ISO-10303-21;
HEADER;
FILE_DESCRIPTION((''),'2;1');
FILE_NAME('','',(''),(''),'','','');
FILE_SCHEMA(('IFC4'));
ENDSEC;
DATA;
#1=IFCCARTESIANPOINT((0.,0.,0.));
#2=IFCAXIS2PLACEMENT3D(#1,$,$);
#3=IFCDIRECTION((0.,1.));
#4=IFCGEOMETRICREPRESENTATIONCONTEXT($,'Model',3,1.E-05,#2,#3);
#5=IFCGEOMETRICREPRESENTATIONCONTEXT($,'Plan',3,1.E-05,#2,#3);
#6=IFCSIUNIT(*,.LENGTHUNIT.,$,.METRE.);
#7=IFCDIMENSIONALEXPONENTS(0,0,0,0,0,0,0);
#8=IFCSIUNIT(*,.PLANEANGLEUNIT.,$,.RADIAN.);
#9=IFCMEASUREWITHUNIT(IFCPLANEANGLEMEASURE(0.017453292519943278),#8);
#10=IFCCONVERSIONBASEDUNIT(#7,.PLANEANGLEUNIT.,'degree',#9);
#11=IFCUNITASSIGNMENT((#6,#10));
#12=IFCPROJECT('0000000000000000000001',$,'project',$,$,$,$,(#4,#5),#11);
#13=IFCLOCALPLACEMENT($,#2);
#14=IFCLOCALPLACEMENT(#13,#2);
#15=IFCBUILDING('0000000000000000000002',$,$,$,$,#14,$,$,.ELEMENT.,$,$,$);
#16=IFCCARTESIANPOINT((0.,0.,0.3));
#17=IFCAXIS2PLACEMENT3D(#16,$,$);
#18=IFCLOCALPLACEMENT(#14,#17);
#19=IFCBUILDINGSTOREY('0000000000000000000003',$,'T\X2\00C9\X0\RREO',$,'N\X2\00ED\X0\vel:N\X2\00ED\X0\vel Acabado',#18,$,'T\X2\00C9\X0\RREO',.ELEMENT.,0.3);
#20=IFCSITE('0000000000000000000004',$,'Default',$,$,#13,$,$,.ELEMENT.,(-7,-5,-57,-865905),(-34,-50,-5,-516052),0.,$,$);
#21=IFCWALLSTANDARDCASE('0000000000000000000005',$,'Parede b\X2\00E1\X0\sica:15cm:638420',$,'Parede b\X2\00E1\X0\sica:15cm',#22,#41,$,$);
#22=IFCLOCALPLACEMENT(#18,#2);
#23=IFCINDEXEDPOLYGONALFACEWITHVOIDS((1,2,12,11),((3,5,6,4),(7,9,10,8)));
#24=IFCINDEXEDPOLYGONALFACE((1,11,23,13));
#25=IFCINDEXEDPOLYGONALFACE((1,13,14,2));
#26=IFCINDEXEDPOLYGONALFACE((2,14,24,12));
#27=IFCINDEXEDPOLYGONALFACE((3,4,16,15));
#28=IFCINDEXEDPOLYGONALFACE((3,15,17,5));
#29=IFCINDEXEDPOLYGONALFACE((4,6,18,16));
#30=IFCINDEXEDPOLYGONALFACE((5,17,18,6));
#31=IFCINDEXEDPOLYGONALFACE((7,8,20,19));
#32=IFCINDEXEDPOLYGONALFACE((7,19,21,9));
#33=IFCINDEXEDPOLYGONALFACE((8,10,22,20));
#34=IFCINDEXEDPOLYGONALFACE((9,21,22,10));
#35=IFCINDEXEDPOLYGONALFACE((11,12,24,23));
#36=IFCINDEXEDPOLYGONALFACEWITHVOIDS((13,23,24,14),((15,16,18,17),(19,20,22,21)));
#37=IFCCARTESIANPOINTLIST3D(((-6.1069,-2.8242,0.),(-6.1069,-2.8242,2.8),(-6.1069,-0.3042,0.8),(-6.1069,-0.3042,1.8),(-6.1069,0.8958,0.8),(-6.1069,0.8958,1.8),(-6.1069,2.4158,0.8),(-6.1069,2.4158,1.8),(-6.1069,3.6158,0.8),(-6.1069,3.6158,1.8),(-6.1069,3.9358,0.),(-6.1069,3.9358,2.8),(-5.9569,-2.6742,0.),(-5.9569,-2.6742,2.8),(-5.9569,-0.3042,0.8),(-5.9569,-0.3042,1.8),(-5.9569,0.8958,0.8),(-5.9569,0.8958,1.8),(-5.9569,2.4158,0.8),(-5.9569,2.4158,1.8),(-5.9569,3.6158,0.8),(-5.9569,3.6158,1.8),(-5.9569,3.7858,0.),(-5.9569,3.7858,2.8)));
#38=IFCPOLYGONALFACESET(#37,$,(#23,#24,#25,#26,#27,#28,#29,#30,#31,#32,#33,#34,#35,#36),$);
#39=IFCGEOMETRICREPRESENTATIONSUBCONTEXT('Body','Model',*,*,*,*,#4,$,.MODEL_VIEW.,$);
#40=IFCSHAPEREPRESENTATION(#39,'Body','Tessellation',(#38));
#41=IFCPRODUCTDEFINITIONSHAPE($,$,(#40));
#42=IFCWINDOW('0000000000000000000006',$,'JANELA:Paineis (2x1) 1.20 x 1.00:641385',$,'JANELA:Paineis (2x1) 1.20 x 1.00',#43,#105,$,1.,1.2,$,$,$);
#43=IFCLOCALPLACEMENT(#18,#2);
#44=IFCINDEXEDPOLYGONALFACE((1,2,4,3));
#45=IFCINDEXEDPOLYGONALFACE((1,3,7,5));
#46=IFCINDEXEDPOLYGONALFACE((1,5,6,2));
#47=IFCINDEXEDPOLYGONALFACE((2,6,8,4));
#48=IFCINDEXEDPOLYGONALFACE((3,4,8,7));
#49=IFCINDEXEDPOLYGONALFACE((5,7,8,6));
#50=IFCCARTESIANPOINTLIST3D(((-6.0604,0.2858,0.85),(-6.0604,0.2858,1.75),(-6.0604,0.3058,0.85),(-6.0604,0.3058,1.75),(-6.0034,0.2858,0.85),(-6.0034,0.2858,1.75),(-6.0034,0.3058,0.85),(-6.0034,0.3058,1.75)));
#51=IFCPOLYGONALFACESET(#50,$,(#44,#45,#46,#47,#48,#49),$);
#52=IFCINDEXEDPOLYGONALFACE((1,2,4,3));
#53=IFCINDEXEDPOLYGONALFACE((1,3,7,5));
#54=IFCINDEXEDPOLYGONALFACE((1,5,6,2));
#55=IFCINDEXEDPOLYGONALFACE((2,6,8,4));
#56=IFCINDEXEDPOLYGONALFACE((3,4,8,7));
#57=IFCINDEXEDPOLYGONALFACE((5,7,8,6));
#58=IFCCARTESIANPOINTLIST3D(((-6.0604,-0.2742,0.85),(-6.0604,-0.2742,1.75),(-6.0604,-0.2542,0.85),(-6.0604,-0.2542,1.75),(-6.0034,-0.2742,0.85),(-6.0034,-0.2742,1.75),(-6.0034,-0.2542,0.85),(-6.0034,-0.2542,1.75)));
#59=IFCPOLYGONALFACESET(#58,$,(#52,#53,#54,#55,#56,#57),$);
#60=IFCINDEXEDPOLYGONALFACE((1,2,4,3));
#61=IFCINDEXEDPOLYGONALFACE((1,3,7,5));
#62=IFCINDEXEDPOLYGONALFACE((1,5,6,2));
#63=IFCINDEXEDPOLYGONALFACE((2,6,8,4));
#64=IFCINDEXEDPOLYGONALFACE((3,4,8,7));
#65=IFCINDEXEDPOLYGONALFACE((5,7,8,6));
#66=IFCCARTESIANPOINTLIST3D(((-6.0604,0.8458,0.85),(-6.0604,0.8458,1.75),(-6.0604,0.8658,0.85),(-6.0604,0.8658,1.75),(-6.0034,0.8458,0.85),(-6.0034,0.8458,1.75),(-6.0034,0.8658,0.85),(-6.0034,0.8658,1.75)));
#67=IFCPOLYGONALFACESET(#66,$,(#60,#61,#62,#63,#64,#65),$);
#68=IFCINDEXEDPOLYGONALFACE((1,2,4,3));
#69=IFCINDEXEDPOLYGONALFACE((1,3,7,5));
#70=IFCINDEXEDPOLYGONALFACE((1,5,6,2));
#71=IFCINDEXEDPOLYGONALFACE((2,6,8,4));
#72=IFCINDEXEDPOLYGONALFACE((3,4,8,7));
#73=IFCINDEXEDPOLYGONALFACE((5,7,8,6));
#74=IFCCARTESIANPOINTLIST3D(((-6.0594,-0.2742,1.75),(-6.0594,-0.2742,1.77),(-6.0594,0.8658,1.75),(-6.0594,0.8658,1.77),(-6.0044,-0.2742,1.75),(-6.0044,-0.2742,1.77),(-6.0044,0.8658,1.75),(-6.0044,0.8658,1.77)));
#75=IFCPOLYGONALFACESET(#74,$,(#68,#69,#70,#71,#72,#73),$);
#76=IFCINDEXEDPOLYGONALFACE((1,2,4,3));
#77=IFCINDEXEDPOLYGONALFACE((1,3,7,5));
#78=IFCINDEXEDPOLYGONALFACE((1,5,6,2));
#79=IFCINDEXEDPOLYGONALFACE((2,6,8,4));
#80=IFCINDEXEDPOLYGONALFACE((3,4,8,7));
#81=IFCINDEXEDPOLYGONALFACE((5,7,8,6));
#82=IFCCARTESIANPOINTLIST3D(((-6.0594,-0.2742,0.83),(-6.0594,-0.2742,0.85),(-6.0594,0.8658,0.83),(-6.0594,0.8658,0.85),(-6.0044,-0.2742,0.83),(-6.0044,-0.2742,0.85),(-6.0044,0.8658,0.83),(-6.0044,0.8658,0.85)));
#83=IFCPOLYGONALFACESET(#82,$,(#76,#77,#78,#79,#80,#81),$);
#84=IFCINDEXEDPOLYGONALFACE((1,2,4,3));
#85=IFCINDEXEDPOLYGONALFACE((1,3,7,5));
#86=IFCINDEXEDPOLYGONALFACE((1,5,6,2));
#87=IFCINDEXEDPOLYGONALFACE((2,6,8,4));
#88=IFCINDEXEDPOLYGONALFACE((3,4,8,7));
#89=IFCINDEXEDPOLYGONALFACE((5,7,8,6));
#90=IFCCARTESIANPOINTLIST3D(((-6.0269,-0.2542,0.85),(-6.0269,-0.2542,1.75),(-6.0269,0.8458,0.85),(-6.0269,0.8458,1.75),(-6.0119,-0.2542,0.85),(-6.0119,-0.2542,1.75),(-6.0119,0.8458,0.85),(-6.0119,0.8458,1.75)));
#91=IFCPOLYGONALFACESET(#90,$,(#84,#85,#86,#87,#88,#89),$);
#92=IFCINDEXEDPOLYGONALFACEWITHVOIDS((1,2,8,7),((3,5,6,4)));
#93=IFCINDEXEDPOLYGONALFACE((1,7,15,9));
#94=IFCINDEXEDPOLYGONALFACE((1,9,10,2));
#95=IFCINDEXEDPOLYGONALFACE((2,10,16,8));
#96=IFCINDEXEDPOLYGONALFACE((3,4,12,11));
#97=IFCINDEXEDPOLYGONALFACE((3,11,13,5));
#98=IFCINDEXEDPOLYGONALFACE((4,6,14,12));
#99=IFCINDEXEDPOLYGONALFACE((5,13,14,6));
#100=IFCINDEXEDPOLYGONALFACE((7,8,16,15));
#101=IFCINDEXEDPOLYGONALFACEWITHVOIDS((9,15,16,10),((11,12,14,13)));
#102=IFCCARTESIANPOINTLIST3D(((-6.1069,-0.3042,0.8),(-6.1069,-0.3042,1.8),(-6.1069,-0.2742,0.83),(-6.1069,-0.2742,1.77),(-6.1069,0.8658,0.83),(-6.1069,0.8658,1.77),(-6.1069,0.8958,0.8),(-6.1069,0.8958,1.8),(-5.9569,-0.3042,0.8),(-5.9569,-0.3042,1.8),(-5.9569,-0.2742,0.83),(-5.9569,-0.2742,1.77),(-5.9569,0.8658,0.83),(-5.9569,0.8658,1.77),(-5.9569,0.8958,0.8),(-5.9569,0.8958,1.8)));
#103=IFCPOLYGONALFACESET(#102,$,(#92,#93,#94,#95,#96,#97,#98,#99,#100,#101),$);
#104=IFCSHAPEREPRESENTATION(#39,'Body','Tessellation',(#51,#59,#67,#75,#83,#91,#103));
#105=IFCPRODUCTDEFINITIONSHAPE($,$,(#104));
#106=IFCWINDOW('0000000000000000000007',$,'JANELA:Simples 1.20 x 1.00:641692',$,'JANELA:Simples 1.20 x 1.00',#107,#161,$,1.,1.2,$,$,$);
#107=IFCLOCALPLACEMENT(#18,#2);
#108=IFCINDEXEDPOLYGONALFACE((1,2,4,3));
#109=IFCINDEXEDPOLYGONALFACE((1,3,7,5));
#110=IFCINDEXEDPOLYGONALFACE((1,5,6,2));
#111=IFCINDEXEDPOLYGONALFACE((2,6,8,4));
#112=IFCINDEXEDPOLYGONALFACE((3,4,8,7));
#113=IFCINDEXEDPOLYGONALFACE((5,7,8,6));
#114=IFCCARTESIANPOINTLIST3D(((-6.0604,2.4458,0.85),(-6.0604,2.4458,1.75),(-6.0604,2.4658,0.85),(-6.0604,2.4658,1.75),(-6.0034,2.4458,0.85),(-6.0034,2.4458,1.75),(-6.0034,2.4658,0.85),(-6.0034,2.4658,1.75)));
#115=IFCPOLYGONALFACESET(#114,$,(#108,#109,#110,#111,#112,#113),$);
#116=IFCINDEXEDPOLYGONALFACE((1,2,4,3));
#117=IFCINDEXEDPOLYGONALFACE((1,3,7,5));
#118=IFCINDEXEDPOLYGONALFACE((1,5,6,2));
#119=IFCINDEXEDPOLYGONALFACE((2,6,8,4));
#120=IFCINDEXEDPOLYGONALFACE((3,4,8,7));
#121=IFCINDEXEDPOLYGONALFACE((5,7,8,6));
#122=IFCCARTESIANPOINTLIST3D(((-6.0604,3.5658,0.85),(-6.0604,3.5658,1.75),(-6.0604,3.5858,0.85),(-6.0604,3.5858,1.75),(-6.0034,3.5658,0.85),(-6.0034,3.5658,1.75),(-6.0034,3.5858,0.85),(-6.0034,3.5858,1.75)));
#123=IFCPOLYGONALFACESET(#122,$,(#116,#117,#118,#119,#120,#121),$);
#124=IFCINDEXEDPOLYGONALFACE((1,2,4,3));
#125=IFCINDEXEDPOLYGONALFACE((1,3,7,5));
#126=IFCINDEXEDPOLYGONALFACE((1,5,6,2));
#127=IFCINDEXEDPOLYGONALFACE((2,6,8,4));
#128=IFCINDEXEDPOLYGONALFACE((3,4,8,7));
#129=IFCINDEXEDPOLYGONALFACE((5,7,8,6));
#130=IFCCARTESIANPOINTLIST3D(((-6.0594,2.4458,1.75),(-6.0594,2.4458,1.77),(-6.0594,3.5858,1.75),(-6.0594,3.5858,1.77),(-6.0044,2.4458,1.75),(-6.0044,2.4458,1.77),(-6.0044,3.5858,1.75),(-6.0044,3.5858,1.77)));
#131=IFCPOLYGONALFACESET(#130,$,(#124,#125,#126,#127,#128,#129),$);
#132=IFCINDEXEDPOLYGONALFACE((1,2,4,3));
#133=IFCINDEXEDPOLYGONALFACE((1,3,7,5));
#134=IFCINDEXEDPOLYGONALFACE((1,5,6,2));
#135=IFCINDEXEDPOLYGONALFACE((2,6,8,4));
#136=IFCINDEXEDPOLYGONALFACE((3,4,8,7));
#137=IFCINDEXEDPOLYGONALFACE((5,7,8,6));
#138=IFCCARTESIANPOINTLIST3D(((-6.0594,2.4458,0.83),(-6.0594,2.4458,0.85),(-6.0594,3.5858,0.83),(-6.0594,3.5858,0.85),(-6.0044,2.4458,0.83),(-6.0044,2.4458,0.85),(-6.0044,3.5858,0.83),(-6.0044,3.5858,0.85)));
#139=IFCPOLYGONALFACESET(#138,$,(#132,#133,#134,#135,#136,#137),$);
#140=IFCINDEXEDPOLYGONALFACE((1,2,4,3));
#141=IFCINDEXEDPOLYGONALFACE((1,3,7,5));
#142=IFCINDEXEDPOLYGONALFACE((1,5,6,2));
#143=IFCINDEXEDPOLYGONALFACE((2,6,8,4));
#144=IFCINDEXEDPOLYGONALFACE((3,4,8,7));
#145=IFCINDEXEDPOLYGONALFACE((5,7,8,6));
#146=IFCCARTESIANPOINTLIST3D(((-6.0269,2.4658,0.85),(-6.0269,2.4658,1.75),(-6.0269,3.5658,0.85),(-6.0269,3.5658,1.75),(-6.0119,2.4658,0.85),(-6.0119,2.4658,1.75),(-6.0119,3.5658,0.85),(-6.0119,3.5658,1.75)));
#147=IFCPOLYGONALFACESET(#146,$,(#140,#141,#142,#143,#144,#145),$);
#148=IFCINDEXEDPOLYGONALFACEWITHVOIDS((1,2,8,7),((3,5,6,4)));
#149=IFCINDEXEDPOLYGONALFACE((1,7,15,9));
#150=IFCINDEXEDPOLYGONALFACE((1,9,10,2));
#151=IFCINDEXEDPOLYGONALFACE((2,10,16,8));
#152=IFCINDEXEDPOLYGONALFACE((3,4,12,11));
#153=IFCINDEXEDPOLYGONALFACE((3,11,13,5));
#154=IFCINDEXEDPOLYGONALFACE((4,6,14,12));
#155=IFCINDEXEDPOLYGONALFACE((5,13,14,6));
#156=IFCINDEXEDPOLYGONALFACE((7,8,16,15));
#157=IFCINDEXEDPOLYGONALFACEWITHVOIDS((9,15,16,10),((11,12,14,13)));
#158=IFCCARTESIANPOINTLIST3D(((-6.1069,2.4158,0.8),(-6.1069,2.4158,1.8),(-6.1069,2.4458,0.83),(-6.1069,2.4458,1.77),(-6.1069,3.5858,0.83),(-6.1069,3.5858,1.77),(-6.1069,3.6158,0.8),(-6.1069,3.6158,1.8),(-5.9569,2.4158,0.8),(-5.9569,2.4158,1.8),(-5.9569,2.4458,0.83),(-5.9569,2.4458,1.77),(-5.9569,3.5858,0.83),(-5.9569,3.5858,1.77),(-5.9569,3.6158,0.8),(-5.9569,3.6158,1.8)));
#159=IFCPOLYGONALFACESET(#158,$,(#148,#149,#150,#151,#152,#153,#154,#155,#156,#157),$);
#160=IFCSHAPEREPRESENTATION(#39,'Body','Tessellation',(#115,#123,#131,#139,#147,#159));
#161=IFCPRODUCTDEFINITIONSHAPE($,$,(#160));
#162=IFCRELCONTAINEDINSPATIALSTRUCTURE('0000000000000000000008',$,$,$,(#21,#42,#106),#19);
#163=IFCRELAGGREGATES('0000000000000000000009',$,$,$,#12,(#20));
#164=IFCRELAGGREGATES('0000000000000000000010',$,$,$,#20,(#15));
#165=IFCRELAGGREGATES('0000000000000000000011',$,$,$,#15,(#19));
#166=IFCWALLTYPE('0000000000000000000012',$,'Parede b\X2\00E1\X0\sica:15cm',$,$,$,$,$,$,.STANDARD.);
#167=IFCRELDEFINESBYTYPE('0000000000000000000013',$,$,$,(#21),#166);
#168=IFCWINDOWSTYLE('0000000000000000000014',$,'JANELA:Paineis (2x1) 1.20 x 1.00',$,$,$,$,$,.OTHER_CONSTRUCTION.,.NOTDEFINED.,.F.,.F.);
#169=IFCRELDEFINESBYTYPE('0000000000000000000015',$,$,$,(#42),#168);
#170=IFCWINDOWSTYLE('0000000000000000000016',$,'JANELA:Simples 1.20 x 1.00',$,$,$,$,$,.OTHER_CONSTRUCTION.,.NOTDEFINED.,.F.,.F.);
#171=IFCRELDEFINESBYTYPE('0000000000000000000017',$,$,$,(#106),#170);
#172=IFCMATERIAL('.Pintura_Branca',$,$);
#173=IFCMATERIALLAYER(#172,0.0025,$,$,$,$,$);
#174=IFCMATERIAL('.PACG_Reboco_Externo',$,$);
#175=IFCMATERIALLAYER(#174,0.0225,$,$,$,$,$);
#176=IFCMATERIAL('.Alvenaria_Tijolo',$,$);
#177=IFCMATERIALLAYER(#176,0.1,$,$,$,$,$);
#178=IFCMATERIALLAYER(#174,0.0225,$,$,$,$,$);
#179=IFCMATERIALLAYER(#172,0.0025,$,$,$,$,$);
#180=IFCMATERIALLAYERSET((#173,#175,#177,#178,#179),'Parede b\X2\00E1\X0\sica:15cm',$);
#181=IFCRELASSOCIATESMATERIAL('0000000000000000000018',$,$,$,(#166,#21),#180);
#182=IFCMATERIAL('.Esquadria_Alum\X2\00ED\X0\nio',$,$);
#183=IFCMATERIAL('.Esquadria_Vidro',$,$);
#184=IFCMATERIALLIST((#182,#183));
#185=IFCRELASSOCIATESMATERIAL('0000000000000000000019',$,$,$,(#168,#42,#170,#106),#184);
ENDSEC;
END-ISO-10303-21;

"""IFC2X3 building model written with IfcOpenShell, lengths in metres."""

from ifc_helpers import new_model, entity, si_unit, converted_unit, direction, frame, frame_2d, origin, origin_2d_with_axis, place, context, subcontext, project, spatial, polyline, rectangle, outline, extrude, source, transform, mapped, material, material_list, layer, layer_set, layer_usage, type_object, type_shapes, element, fill, save


model = new_model("IFC2X3")

# Units and contexts
model_context = context("Model", 3, precision=1e-05, world=origin(), true_north=direction((0.0, 1.0)))
plan_context = context("Plan", 3, precision=1e-05, world=origin(), true_north=direction((0.0, 1.0)))
body_context = subcontext(model_context, "Body", "Model", "MODEL_VIEW")
ifc_project = project(units=[si_unit("LENGTHUNIT", "METRE"), converted_unit("PLANEANGLEUNIT", "degree", entity("IfcPlaneAngleMeasure", 0.017453292519943278), si_unit("PLANEANGLEUNIT", "RADIAN"), dimensions=[0, 0, 0, 0, 0, 0, 0])], contexts=[model_context, plan_context])

# Site, building, storey
site_placement = place(None, origin())
site = spatial("IfcSite", under=ifc_project, at=site_placement, Name="Default", CompositionType="ELEMENT", RefLatitude=(-7, -5, -57, -865905), RefLongitude=(-34, -50, -5, -516052), RefElevation=0.0)
building_placement = place(site_placement, origin())
building = spatial("IfcBuilding", under=site, at=building_placement, CompositionType="ELEMENT")
storey_placement = place(building_placement, frame((0.0, 0.0, 0.3)))
storey = spatial("IfcBuildingStorey", under=building, at=storey_placement, Name="TÉRREO", ObjectType="Nível:Nível Acabado", LongName="TÉRREO", CompositionType="ELEMENT", Elevation=0.3)

# Wall, openings, windows
ifc_material_1 = material(Name=".Pintura_Branca")
ifc_layer_1 = layer(ifc_material_1, 0.0025)
ifc_material_2 = material(Name=".PACG_Reboco_Externo")
ifc_layer_2 = layer(ifc_material_2, 0.0225)
ifc_material_3 = material(Name=".Alvenaria_Tijolo")
ifc_layer_3 = layer(ifc_material_3, 0.1)
ifc_layer_4 = layer(ifc_material_2, 0.0225)
ifc_layer_5 = layer(ifc_material_1, 0.0025)
ifc_layer_set_1 = layer_set([ifc_layer_1, ifc_layer_2, ifc_layer_3, ifc_layer_4, ifc_layer_5], Name="Parede básica:15cm")
ifc_layer_usage_1 = layer_usage(ifc_layer_set_1, "AXIS2", "NEGATIVE", 0.075)
wall_type = type_object("IfcWallType", Name="Parede básica:15cm", PredefinedType="STANDARD", material=ifc_layer_set_1)
wall_1_placement = place(storey_placement, frame((-6.0319, 3.9358, 0.0), z_axis=(0.0, 0.0, 1.0), x_axis=(0.0, -1.0, 0.0)))
wall_1 = element("IfcWallStandardCase", 1, at=wall_1_placement, inside=storey, type_object=wall_type, material=ifc_layer_usage_1, Name="Parede básica:15cm:638420", ObjectType="Parede básica:15cm", context=body_context, shape_type="SweptSolid", body=[
    extrude(outline(polyline([(6.76, -0.075), (6.61, 0.075), (1.84, 0.075), (1.69, 0.075), (0.15, 0.075), (0.0, -0.075), (6.76, -0.075)])), origin(), (0.0, 0.0, 1.0), 2.8),
])
opening_1_placement = place(wall_1_placement, frame((4.24, 0.075, 0.8)))
opening_1 = element("IfcOpeningElement", 2, at=opening_1_placement, cuts=wall_1, ObjectType="Opening", context=body_context, shape_type="SweptSolid", body=[
    extrude(rectangle(XDim=1.0, YDim=1.2, at=frame_2d((0.5, 0.6), x_axis=(1.0, 0.0))), frame((0.0, 0.0, 0.0), z_axis=(0.0, -1.0, 0.0), x_axis=(0.0, 0.0, 1.0)), (0.0, 0.0, 1.0), 0.15),
])
opening_2_placement = place(wall_1_placement, frame((1.52, 0.075, 0.8)))
opening_2 = element("IfcOpeningElement", 3, at=opening_2_placement, cuts=wall_1, ObjectType="Opening", context=body_context, shape_type="SweptSolid", body=[
    extrude(rectangle(XDim=1.0, YDim=1.2, at=frame_2d((0.5, 0.6), x_axis=(1.0, 0.0))), frame((0.0, 0.0, 0.0), z_axis=(0.0, -1.0, 0.0), x_axis=(0.0, 0.0, 1.0)), (0.0, 0.0, 1.0), 0.15),
])
ifc_material_4 = material(Name=".Esquadria_Alumínio")
ifc_material_5 = material(Name=".Esquadria_Vidro")
ifc_material_list = material_list([ifc_material_4, ifc_material_5])
window_style_1 = type_object("IfcWindowStyle", Name="JANELA:Paineis (2x1) 1.20 x 1.00", ConstructionType="OTHER_CONSTRUCTION", OperationType="NOTDEFINED", ParameterTakesPrecedence=False, Sizeable=False, material=ifc_material_list)
shared_shape_1 = source(origin(), body_context, "Body", "SweptSolid", [
    extrude(rectangle(XDim=0.02, YDim=0.057, at=origin_2d_with_axis()), frame((0.6, 0.075, 0.05), z_axis=(0.0, 0.0, 1.0), x_axis=(-1.0, 0.0, 0.0)), (0.0, 0.0, 1.0), 0.9),
    extrude(rectangle(XDim=0.02, YDim=0.057, at=frame_2d((0.0, 0.0), x_axis=(1.0, 0.0))), frame((0.04, 0.075, 0.05), z_axis=(0.0, 0.0, 1.0), x_axis=(-1.0, 0.0, 0.0)), (0.0, 0.0, 1.0), 0.9),
    extrude(rectangle(XDim=0.02, YDim=0.057, at=frame_2d((0.0, 0.0), x_axis=(1.0, 0.0))), frame((1.16, 0.075, 0.05), z_axis=(0.0, 0.0, 1.0), x_axis=(-1.0, 0.0, 0.0)), (0.0, 0.0, 1.0), 0.9),
    extrude(rectangle(XDim=1.14, YDim=0.055, at=frame_2d((0.0, 0.0), x_axis=(1.0, 0.0))), frame((0.6, 0.075, 0.95), z_axis=(0.0, 0.0, 1.0), x_axis=(-1.0, 0.0, 0.0)), (0.0, 0.0, 1.0), 0.02),
    extrude(rectangle(XDim=1.14, YDim=0.055, at=frame_2d((0.0, 0.0), x_axis=(1.0, 0.0))), frame((0.6, 0.075, 0.03), z_axis=(0.0, 0.0, 1.0), x_axis=(-1.0, 0.0, 0.0)), (0.0, 0.0, 1.0), 0.02),
    extrude(rectangle(XDim=0.015, YDim=1.1, at=frame_2d((0.0, 0.0), x_axis=(1.0, 0.0))), frame((0.6, 0.0625, 0.05), z_axis=(0.0, 0.0, 1.0), x_axis=(0.0, 1.0, 0.0)), (0.0, 0.0, 1.0), 0.9),
    extrude(outline(polyline([(-0.6, -0.5), (0.6, -0.5), (0.6, 0.5), (-0.6, 0.5), (-0.6, -0.5)]), holes=[polyline([(0.57, -0.47), (-0.57, -0.47), (-0.57, 0.47), (0.57, 0.47), (0.57, -0.47)])]), frame((0.6, 0.0, 0.5), z_axis=(0.0, 1.0, 0.0), x_axis=(1.0, 0.0, 0.0)), (0.0, 0.0, 1.0), 0.15),
])
type_shapes(window_style_1, [shared_shape_1])
window_1_placement = place(opening_1_placement, frame((0.0, 0.0, 0.0), z_axis=(0.0, 0.0, 1.0), x_axis=(-1.0, 0.0, 0.0)))
window_1 = element("IfcWindow", 4, at=window_1_placement, inside=storey, type_object=window_style_1, material=ifc_material_list, Name="JANELA:Paineis (2x1) 1.20 x 1.00:641385", ObjectType="JANELA:Paineis (2x1) 1.20 x 1.00", OverallHeight=1.0, OverallWidth=1.2, context=body_context, shape_type="MappedRepresentation", body=[
    mapped(shared_shape_1, transform((0.0, 0.0, 0.0), scale=1.0)),
])
fill(opening_1, window_1)
window_style_2 = type_object("IfcWindowStyle", Name="JANELA:Simples 1.20 x 1.00", ConstructionType="OTHER_CONSTRUCTION", OperationType="NOTDEFINED", ParameterTakesPrecedence=False, Sizeable=False, material=ifc_material_list)
shared_shape_2 = source(origin(), body_context, "Body", "SweptSolid", [
    extrude(rectangle(XDim=0.02, YDim=0.057, at=frame_2d((0.0, 0.0), x_axis=(1.0, 0.0))), frame((0.04, 0.075, 0.05), z_axis=(0.0, 0.0, 1.0), x_axis=(-1.0, 0.0, 0.0)), (0.0, 0.0, 1.0), 0.9),
    extrude(rectangle(XDim=0.02, YDim=0.057, at=frame_2d((0.0, 0.0), x_axis=(1.0, 0.0))), frame((1.16, 0.075, 0.05), z_axis=(0.0, 0.0, 1.0), x_axis=(-1.0, 0.0, 0.0)), (0.0, 0.0, 1.0), 0.9),
    extrude(rectangle(XDim=1.14, YDim=0.055, at=frame_2d((0.0, 0.0), x_axis=(1.0, 0.0))), frame((0.6, 0.075, 0.95), z_axis=(0.0, 0.0, 1.0), x_axis=(-1.0, 0.0, 0.0)), (0.0, 0.0, 1.0), 0.02),
    extrude(rectangle(XDim=1.14, YDim=0.055, at=frame_2d((0.0, 0.0), x_axis=(1.0, 0.0))), frame((0.6, 0.075, 0.03), z_axis=(0.0, 0.0, 1.0), x_axis=(-1.0, 0.0, 0.0)), (0.0, 0.0, 1.0), 0.02),
    extrude(rectangle(XDim=0.015, YDim=1.1, at=frame_2d((0.0, 0.0), x_axis=(1.0, 0.0))), frame((0.6, 0.0625, 0.05), z_axis=(0.0, 0.0, 1.0), x_axis=(0.0, 1.0, 0.0)), (0.0, 0.0, 1.0), 0.9),
    extrude(outline(polyline([(-0.6, -0.5), (0.6, -0.5), (0.6, 0.5), (-0.6, 0.5), (-0.6, -0.5)]), holes=[polyline([(0.57, -0.47), (-0.57, -0.47), (-0.57, 0.47), (0.57, 0.47), (0.57, -0.47)])]), frame((0.6, 0.0, 0.5), z_axis=(0.0, 1.0, 0.0), x_axis=(1.0, 0.0, 0.0)), (0.0, 0.0, 1.0), 0.15),
])
type_shapes(window_style_2, [shared_shape_2])
window_2_placement = place(opening_2_placement, frame((0.0, 0.0, 0.0), z_axis=(0.0, 0.0, 1.0), x_axis=(-1.0, 0.0, 0.0)))
window_2 = element("IfcWindow", 5, at=window_2_placement, inside=storey, type_object=window_style_2, material=ifc_material_list, Name="JANELA:Simples 1.20 x 1.00:641692", ObjectType="JANELA:Simples 1.20 x 1.00", OverallHeight=1.0, OverallWidth=1.2, context=body_context, shape_type="MappedRepresentation", body=[
    mapped(shared_shape_2, transform((0.0, 0.0, 0.0), scale=1.0)),
])
fill(opening_2, window_2)

save(model, "model.ifc")
